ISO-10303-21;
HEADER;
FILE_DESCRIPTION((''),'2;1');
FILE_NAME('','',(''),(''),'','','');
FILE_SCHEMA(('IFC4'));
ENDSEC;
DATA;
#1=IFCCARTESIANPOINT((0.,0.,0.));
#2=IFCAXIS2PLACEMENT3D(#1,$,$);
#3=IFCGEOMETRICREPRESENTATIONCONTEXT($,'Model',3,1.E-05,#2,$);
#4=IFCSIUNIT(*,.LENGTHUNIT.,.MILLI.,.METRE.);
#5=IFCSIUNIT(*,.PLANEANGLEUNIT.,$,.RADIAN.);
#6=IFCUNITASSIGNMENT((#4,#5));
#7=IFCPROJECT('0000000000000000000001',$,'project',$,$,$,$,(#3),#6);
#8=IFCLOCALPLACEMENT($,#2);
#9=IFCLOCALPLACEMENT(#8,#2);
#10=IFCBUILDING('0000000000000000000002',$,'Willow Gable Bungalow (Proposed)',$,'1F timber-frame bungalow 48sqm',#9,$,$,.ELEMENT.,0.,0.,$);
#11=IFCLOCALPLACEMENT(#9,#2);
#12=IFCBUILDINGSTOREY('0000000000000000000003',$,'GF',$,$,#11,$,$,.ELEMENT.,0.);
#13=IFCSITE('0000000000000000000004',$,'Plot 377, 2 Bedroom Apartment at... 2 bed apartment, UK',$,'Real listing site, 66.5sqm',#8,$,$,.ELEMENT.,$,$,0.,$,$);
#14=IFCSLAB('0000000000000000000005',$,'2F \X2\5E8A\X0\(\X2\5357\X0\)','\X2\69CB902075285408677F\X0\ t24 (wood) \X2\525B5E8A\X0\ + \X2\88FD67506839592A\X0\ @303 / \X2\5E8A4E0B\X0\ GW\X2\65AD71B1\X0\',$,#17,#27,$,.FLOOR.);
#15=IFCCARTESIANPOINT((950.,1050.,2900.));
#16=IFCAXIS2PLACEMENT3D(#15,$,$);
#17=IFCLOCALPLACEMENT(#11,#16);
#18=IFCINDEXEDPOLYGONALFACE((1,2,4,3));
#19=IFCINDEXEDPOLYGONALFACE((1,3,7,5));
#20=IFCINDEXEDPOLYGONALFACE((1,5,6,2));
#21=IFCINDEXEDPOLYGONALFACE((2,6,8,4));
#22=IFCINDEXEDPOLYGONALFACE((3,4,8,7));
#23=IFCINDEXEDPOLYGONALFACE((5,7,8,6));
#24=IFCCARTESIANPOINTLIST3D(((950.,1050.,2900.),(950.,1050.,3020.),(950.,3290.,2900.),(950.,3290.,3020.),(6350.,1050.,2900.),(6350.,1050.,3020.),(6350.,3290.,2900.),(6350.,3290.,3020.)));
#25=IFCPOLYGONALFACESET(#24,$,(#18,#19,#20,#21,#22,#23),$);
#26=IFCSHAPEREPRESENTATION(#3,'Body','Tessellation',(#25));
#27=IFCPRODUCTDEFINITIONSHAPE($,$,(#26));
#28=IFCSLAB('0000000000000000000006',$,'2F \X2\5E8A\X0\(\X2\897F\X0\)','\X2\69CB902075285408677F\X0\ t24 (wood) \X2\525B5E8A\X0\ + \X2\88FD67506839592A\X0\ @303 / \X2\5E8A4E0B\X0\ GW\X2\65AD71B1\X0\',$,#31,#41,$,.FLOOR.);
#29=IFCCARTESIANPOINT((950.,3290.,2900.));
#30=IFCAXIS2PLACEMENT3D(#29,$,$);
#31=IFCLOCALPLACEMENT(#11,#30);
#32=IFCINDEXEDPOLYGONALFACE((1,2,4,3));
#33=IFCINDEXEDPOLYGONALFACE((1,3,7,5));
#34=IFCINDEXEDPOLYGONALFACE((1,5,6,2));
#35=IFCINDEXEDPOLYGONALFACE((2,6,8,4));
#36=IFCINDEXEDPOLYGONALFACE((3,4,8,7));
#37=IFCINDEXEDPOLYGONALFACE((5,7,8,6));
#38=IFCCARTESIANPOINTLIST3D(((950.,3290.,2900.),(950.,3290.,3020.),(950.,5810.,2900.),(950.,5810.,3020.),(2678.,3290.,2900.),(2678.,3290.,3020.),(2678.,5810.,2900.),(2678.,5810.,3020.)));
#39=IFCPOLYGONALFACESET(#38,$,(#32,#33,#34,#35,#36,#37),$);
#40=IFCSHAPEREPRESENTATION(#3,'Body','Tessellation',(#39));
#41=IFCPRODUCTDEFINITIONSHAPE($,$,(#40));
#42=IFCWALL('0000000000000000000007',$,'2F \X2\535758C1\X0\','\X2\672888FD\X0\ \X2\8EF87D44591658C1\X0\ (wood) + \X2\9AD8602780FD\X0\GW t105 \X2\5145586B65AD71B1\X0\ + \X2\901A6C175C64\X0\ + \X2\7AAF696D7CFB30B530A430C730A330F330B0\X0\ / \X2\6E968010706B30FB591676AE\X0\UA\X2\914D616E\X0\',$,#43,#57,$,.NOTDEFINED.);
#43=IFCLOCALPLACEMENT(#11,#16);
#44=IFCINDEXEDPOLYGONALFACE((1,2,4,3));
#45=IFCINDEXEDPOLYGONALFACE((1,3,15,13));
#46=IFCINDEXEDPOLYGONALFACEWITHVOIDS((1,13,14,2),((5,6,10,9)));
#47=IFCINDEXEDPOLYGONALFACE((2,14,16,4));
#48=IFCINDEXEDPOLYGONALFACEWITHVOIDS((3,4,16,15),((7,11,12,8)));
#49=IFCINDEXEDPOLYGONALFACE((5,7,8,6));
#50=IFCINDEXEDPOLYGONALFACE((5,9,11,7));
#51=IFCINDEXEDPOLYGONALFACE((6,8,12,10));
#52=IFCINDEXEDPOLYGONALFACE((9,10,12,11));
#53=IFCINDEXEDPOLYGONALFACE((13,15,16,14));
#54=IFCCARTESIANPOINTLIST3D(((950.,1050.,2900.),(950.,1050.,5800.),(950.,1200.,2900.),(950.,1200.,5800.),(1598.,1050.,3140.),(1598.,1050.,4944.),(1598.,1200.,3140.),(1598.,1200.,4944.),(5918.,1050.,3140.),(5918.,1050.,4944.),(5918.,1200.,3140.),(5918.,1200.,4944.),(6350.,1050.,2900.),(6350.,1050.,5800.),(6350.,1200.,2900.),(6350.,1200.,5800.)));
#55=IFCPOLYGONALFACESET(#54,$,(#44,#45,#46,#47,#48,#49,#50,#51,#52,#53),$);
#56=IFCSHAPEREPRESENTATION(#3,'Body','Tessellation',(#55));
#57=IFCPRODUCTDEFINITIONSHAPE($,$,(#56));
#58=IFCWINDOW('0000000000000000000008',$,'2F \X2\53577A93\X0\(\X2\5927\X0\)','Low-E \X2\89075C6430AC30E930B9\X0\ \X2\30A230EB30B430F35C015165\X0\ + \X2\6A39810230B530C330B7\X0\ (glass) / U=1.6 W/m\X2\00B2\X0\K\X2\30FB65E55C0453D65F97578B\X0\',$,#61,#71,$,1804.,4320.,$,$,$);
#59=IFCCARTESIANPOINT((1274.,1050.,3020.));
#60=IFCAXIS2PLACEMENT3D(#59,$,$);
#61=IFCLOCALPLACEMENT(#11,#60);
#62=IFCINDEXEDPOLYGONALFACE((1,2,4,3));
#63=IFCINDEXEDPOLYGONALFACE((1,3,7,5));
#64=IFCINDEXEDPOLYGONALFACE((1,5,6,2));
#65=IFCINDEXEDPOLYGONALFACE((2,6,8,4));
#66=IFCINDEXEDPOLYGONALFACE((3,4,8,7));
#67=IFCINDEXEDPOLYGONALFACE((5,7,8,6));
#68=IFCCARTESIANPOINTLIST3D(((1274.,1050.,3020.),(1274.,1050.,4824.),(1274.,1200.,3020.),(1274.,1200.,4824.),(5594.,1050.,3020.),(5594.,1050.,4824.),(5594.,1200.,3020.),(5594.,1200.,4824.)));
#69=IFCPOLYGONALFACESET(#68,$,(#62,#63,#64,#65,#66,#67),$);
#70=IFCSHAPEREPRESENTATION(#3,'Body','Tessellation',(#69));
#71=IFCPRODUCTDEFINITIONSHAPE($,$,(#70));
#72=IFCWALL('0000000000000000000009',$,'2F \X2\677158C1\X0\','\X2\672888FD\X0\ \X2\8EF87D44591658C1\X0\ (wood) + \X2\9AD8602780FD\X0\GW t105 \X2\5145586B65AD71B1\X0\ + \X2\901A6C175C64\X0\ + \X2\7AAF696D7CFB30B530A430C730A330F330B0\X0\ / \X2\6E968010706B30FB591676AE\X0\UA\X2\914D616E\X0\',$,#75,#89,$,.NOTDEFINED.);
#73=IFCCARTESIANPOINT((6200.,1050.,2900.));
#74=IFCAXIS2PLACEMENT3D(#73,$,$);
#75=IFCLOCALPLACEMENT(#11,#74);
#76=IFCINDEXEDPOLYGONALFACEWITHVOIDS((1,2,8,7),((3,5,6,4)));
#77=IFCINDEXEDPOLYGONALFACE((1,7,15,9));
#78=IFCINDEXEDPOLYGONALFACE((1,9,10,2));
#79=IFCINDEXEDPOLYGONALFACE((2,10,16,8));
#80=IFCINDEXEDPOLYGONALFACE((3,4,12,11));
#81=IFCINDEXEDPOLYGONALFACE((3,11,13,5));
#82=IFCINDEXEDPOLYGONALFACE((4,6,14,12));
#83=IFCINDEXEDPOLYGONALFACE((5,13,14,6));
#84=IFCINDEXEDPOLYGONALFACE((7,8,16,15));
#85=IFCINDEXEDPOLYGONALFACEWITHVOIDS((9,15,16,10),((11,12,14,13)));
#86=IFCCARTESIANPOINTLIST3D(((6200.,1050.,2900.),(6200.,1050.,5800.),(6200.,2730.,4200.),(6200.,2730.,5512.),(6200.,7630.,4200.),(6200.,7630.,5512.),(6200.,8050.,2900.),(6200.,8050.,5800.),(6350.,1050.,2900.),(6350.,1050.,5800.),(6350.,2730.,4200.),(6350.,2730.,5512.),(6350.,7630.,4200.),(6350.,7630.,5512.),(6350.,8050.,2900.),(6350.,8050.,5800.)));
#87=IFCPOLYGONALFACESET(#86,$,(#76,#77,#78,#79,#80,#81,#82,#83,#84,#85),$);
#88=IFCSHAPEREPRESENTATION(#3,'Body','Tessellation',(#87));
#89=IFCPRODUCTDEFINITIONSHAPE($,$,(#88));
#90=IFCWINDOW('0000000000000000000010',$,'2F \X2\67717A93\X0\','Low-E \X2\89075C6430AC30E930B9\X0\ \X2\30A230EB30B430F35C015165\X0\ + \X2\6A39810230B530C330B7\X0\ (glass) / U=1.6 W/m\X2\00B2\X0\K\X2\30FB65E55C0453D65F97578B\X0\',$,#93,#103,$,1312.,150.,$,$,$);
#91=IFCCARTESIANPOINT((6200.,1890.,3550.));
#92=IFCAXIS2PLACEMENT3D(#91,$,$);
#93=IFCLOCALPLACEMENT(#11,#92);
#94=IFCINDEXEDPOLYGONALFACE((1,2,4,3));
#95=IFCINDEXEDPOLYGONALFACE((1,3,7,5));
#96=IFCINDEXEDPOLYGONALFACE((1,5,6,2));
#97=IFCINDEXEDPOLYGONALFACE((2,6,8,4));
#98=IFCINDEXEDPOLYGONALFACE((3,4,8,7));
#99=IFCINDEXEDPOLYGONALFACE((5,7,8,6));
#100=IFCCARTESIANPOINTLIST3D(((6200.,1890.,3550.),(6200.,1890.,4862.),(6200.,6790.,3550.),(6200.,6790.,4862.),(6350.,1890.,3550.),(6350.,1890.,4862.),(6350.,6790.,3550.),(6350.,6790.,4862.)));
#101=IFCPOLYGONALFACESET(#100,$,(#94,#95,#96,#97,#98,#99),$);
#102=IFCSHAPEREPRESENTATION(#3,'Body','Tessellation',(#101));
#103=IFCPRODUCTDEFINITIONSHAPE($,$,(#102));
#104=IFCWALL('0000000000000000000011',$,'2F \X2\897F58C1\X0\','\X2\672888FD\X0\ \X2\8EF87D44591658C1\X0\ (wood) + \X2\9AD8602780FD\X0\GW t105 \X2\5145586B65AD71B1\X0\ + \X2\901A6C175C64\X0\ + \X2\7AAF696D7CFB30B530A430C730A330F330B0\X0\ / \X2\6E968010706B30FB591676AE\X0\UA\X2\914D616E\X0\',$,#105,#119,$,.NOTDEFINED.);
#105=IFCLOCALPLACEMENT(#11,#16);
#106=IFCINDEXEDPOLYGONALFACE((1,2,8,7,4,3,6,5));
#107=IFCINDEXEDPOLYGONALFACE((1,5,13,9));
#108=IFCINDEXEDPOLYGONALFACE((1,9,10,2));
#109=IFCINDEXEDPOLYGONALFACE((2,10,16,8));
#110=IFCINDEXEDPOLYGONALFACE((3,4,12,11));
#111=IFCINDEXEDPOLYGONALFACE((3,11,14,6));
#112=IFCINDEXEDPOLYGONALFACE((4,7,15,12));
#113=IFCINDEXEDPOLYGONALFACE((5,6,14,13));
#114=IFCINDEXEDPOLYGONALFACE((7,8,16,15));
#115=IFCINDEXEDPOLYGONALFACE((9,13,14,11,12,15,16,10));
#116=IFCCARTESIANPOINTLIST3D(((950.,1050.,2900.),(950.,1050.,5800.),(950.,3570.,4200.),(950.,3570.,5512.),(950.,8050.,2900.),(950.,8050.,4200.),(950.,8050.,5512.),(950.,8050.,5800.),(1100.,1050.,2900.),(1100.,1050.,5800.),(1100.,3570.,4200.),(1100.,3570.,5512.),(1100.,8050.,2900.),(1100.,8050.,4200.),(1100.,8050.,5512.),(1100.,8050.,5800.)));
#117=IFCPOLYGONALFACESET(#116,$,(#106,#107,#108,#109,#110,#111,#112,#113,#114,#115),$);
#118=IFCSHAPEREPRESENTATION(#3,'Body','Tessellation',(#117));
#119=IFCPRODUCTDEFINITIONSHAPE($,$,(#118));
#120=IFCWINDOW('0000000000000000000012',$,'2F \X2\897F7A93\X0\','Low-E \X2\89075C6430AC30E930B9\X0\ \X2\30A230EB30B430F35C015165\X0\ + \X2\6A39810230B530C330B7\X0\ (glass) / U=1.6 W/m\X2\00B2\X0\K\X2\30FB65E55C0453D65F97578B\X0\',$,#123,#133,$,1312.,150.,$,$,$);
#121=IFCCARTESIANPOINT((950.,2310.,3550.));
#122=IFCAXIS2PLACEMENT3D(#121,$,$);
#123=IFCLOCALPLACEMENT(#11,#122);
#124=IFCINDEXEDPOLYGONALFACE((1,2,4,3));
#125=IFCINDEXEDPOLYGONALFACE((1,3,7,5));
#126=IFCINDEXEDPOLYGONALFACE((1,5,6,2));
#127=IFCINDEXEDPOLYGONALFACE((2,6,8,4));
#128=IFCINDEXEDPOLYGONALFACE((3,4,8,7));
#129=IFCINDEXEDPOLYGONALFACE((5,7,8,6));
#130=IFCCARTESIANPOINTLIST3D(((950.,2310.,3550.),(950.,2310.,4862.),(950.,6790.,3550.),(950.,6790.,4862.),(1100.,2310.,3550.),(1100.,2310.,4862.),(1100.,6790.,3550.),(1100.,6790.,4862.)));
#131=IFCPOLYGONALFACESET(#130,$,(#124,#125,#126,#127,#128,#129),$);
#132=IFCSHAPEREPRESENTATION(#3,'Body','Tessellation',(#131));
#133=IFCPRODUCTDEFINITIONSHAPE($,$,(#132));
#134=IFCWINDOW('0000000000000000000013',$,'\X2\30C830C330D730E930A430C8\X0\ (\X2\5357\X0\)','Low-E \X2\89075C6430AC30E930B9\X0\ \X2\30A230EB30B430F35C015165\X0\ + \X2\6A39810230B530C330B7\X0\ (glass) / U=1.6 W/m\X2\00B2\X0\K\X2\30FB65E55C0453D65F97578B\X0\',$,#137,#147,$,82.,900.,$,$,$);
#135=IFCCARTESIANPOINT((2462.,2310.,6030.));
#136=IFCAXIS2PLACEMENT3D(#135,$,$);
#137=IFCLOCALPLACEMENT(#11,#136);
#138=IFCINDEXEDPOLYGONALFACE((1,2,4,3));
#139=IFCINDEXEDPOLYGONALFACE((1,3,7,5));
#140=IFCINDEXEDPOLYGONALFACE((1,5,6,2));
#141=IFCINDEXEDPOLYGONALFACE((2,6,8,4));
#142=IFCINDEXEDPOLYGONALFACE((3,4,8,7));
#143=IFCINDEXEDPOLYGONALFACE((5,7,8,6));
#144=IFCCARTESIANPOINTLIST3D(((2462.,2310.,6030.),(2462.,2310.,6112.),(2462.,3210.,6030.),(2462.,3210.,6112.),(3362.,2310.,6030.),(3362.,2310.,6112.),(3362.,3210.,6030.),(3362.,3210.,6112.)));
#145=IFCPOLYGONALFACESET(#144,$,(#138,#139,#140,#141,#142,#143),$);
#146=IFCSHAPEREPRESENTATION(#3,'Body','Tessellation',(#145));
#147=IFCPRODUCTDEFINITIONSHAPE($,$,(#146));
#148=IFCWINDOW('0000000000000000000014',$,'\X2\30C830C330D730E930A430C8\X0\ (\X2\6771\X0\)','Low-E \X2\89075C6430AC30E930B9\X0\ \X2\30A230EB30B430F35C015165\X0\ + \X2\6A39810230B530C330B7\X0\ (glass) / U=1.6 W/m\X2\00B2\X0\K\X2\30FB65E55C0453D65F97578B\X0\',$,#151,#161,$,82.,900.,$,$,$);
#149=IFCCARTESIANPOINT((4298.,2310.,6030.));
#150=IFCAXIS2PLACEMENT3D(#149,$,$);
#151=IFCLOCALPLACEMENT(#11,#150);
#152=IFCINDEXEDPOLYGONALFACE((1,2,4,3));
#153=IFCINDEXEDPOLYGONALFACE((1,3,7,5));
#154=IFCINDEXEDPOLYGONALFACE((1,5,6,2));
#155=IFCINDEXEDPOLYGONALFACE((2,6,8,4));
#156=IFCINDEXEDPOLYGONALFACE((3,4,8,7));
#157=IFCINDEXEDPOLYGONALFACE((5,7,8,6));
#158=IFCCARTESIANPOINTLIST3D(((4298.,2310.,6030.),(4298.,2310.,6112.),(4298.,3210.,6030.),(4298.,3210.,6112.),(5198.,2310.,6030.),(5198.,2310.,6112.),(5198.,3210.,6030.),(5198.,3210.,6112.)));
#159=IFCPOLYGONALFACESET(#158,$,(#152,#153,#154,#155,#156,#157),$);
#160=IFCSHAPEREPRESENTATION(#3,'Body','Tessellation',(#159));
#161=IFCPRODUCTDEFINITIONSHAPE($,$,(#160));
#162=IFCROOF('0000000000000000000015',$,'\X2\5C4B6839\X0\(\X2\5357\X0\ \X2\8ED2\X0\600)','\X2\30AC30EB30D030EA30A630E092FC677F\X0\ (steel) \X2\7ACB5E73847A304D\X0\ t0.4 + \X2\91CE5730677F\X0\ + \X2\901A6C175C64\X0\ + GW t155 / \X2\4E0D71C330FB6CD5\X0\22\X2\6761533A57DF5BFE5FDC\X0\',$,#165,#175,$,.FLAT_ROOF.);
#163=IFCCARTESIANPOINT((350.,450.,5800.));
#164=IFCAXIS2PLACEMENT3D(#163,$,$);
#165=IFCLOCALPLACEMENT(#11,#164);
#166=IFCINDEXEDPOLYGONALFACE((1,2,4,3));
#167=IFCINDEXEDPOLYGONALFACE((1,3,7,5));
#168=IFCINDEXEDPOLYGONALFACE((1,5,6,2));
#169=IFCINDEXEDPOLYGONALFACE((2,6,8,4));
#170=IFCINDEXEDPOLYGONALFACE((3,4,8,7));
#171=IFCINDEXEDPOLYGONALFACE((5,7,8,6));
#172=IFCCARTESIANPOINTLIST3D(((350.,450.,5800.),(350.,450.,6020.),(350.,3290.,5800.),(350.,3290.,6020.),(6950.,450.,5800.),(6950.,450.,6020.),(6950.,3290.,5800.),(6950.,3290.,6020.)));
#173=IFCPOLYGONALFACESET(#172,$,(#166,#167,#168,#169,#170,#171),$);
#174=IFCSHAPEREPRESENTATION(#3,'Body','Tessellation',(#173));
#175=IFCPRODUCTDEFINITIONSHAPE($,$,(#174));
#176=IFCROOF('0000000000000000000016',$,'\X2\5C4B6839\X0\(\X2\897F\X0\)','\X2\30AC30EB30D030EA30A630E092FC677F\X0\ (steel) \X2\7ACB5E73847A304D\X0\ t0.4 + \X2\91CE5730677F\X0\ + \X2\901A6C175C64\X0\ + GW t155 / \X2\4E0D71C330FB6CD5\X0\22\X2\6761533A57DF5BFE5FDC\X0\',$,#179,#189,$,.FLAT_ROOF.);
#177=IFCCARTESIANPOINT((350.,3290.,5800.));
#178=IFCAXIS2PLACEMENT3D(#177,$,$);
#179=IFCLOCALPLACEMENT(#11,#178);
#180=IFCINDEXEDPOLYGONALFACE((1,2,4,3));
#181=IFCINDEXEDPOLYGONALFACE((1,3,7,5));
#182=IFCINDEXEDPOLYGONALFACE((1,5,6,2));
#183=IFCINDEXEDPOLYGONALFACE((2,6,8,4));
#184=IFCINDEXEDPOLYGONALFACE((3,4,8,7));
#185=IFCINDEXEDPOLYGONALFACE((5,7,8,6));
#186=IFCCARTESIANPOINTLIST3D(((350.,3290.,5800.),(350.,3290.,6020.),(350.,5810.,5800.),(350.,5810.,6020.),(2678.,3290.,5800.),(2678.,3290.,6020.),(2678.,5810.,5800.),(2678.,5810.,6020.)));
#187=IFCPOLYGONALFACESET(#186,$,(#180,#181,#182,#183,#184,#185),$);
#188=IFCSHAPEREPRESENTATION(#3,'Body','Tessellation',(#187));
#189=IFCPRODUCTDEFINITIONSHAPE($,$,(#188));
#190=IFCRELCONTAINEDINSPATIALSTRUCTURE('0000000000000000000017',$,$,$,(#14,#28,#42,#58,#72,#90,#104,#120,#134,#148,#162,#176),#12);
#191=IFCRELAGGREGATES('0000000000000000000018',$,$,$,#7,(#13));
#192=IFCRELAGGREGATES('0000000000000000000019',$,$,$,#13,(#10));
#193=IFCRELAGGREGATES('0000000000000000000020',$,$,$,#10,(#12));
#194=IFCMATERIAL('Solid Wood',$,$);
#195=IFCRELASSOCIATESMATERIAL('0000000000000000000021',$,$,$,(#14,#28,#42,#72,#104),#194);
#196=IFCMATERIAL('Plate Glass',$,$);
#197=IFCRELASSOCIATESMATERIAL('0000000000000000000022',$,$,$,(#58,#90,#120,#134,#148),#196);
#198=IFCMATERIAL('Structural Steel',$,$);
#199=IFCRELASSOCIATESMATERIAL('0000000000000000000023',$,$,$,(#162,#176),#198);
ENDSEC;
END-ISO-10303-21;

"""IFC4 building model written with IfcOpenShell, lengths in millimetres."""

from ifc_helpers import new_model, si_unit, frame, frame_2d, origin, place, context, project, spatial, rectangle, extrude, material, element, fill, save


model = new_model("IFC4")

# Units and contexts
model_context = context("Model", 3, precision=1e-05, world=origin())
ifc_project = project(units=[si_unit("LENGTHUNIT", "METRE", prefix="MILLI"), si_unit("PLANEANGLEUNIT", "RADIAN")], contexts=[model_context])

# Site, building, storey
site_placement = place(None, origin())
site = spatial("IfcSite", under=ifc_project, at=site_placement, Name="Plot 377, 2 Bedroom Apartment at... 2 bed apartment, UK", ObjectType="Real listing site, 66.5sqm", CompositionType="ELEMENT", RefElevation=0.0)
building_placement = place(site_placement, origin())
building = spatial("IfcBuilding", under=site, at=building_placement, Name="Willow Gable Bungalow (Proposed)", ObjectType="1F timber-frame bungalow 48sqm", CompositionType="ELEMENT", ElevationOfRefHeight=0.0, ElevationOfTerrain=0.0)
storey_placement = place(building_placement, origin())
storey = spatial("IfcBuildingStorey", under=building, at=storey_placement, Name="GF", CompositionType="ELEMENT", Elevation=0.0)

# Slabs
ifc_material_1 = material(Name="Solid Wood")
slab_1_placement = place(storey_placement, frame((950.0, 1050.0, 2900.0)))
element("IfcSlab", 1, at=slab_1_placement, inside=storey, material=ifc_material_1, Name="2F 床(南)", Description="構造用合板 t24 (wood) 剛床 + 製材根太 @303 / 床下 GW断熱", PredefinedType="FLOOR", context=model_context, shape_type="SweptSolid", body=[
    extrude(rectangle(XDim=5400.0, YDim=2240.0, at=frame_2d((2700.0, 1120.0))), frame((950.0, 1050.0, 2900.0)), (0.0, 0.0, 1.0), 120.0),
])
slab_2_placement = place(storey_placement, frame((950.0, 3290.0, 2900.0)))
element("IfcSlab", 2, at=slab_2_placement, inside=storey, material=ifc_material_1, Name="2F 床(西)", Description="構造用合板 t24 (wood) 剛床 + 製材根太 @303 / 床下 GW断熱", PredefinedType="FLOOR", context=model_context, shape_type="SweptSolid", body=[
    extrude(rectangle(XDim=1728.0, YDim=2520.0, at=frame_2d((864.0, 1260.0))), frame((950.0, 3290.0, 2900.0)), (0.0, 0.0, 1.0), 120.0),
])

# Walls, openings, windows
wall_1_placement = place(storey_placement, frame((950.0, 1050.0, 2900.0)))
wall_1 = element("IfcWall", 3, at=wall_1_placement, inside=storey, material=ifc_material_1, Name="2F 南壁", Description="木製 軸組外壁 (wood) + 高性能GW t105 充填断熱 + 通気層 + 窯業系サイディング / 準耐火・外皮UA配慮", PredefinedType="NOTDEFINED", context=model_context, shape_type="SweptSolid", body=[
    extrude(rectangle(XDim=5400.0, YDim=150.0, at=frame_2d((2700.0, 75.0))), frame((950.0, 1050.0, 2900.0)), (0.0, 0.0, 1.0), 2900.0),
])
opening_1_placement = place(storey_placement, frame((1274.0, 1050.0, 3020.0)))
opening_1 = element("IfcOpeningElement", 4, at=opening_1_placement, cuts=wall_1, PredefinedType="NOTDEFINED", context=model_context, shape_type="SweptSolid", body=[
    extrude(rectangle(XDim=4320.0, YDim=150.0, at=frame_2d((2160.0, 75.0))), frame((1274.0, 1050.0, 3020.0)), (0.0, 0.0, 1.0), 1804.0),
])
ifc_material_2 = material(Name="Plate Glass")
window_1_placement = place(storey_placement, frame((1274.0, 1050.0, 3020.0)))
window_1 = element("IfcWindow", 5, at=window_1_placement, inside=storey, material=ifc_material_2, Name="2F 南窓(大)", Description="Low-E 複層ガラス アルゴン封入 + 樹脂サッシ (glass) / U=1.6 W/m²K・日射取得型", OverallHeight=1804.0, OverallWidth=4320.0, context=model_context, shape_type="SweptSolid", body=[
    extrude(rectangle(XDim=4320.0, YDim=150.0, at=frame_2d((2160.0, 75.0))), frame((1274.0, 1050.0, 3020.0)), (0.0, 0.0, 1.0), 1804.0),
])
fill(opening_1, window_1)
wall_2_placement = place(storey_placement, frame((6200.0, 1050.0, 2900.0)))
wall_2 = element("IfcWall", 6, at=wall_2_placement, inside=storey, material=ifc_material_1, Name="2F 東壁", Description="木製 軸組外壁 (wood) + 高性能GW t105 充填断熱 + 通気層 + 窯業系サイディング / 準耐火・外皮UA配慮", PredefinedType="NOTDEFINED", context=model_context, shape_type="SweptSolid", body=[
    extrude(rectangle(XDim=150.0, YDim=7000.0, at=frame_2d((75.0, 3500.0))), frame((6200.0, 1050.0, 2900.0)), (0.0, 0.0, 1.0), 2900.0),
])
opening_2_placement = place(storey_placement, frame((6200.0, 1890.0, 3550.0)))
opening_2 = element("IfcOpeningElement", 7, at=opening_2_placement, cuts=wall_2, PredefinedType="NOTDEFINED", context=model_context, shape_type="SweptSolid", body=[
    extrude(rectangle(XDim=150.0, YDim=4900.0, at=frame_2d((75.0, 2450.0))), frame((6200.0, 1890.0, 3550.0)), (0.0, 0.0, 1.0), 1312.0),
])
window_2_placement = place(storey_placement, frame((6200.0, 1890.0, 3550.0)))
window_2 = element("IfcWindow", 8, at=window_2_placement, inside=storey, material=ifc_material_2, Name="2F 東窓", Description="Low-E 複層ガラス アルゴン封入 + 樹脂サッシ (glass) / U=1.6 W/m²K・日射取得型", OverallHeight=1312.0, OverallWidth=150.0, context=model_context, shape_type="SweptSolid", body=[
    extrude(rectangle(XDim=150.0, YDim=4900.0, at=frame_2d((75.0, 2450.0))), frame((6200.0, 1890.0, 3550.0)), (0.0, 0.0, 1.0), 1312.0),
])
fill(opening_2, window_2)
wall_3_placement = place(storey_placement, frame((950.0, 1050.0, 2900.0)))
wall_3 = element("IfcWall", 9, at=wall_3_placement, inside=storey, material=ifc_material_1, Name="2F 西壁", Description="木製 軸組外壁 (wood) + 高性能GW t105 充填断熱 + 通気層 + 窯業系サイディング / 準耐火・外皮UA配慮", PredefinedType="NOTDEFINED", context=model_context, shape_type="SweptSolid", body=[
    extrude(rectangle(XDim=150.0, YDim=7000.0, at=frame_2d((75.0, 3500.0))), frame((950.0, 1050.0, 2900.0)), (0.0, 0.0, 1.0), 2900.0),
])
opening_3_placement = place(storey_placement, frame((950.0, 2310.0, 3550.0)))
opening_3 = element("IfcOpeningElement", 10, at=opening_3_placement, cuts=wall_3, PredefinedType="NOTDEFINED", context=model_context, shape_type="SweptSolid", body=[
    extrude(rectangle(XDim=150.0, YDim=4480.0, at=frame_2d((75.0, 2240.0))), frame((950.0, 2310.0, 3550.0)), (0.0, 0.0, 1.0), 1312.0),
])
window_3_placement = place(storey_placement, frame((950.0, 2310.0, 3550.0)))
window_3 = element("IfcWindow", 11, at=window_3_placement, inside=storey, material=ifc_material_2, Name="2F 西窓", Description="Low-E 複層ガラス アルゴン封入 + 樹脂サッシ (glass) / U=1.6 W/m²K・日射取得型", OverallHeight=1312.0, OverallWidth=150.0, context=model_context, shape_type="SweptSolid", body=[
    extrude(rectangle(XDim=150.0, YDim=4480.0, at=frame_2d((75.0, 2240.0))), frame((950.0, 2310.0, 3550.0)), (0.0, 0.0, 1.0), 1312.0),
])
fill(opening_3, window_3)

# Windows
window_4_placement = place(storey_placement, frame((2462.0, 2310.0, 6030.0)))
element("IfcWindow", 12, at=window_4_placement, inside=storey, material=ifc_material_2, Name="トップライト (南)", Description="Low-E 複層ガラス アルゴン封入 + 樹脂サッシ (glass) / U=1.6 W/m²K・日射取得型", OverallHeight=82.0, OverallWidth=900.0, context=model_context, shape_type="SweptSolid", body=[
    extrude(rectangle(XDim=900.0, YDim=900.0, at=frame_2d((450.0, 450.0))), frame((2462.0, 2310.0, 6030.0)), (0.0, 0.0, 1.0), 82.0),
])
window_5_placement = place(storey_placement, frame((4298.0, 2310.0, 6030.0)))
element("IfcWindow", 13, at=window_5_placement, inside=storey, material=ifc_material_2, Name="トップライト (東)", Description="Low-E 複層ガラス アルゴン封入 + 樹脂サッシ (glass) / U=1.6 W/m²K・日射取得型", OverallHeight=82.0, OverallWidth=900.0, context=model_context, shape_type="SweptSolid", body=[
    extrude(rectangle(XDim=900.0, YDim=900.0, at=frame_2d((450.0, 450.0))), frame((4298.0, 2310.0, 6030.0)), (0.0, 0.0, 1.0), 82.0),
])

# Roofs
ifc_material_3 = material(Name="Structural Steel")
roof_1_placement = place(storey_placement, frame((350.0, 450.0, 5800.0)))
element("IfcRoof", 14, at=roof_1_placement, inside=storey, material=ifc_material_3, Name="屋根(南 軒600)", Description="ガルバリウム鋼板 (steel) 立平葺き t0.4 + 野地板 + 通気層 + GW t155 / 不燃・法22条区域対応", PredefinedType="FLAT_ROOF", context=model_context, shape_type="SweptSolid", body=[
    extrude(rectangle(XDim=6600.0, YDim=2840.0, at=frame_2d((3300.0, 1420.0))), frame((350.0, 450.0, 5800.0)), (0.0, 0.0, 1.0), 220.0),
])
roof_2_placement = place(storey_placement, frame((350.0, 3290.0, 5800.0)))
element("IfcRoof", 15, at=roof_2_placement, inside=storey, material=ifc_material_3, Name="屋根(西)", Description="ガルバリウム鋼板 (steel) 立平葺き t0.4 + 野地板 + 通気層 + GW t155 / 不燃・法22条区域対応", PredefinedType="FLAT_ROOF", context=model_context, shape_type="SweptSolid", body=[
    extrude(rectangle(XDim=2328.0, YDim=2520.0, at=frame_2d((1164.0, 1260.0))), frame((350.0, 3290.0, 5800.0)), (0.0, 0.0, 1.0), 220.0),
])

save(model, "model.ifc")
